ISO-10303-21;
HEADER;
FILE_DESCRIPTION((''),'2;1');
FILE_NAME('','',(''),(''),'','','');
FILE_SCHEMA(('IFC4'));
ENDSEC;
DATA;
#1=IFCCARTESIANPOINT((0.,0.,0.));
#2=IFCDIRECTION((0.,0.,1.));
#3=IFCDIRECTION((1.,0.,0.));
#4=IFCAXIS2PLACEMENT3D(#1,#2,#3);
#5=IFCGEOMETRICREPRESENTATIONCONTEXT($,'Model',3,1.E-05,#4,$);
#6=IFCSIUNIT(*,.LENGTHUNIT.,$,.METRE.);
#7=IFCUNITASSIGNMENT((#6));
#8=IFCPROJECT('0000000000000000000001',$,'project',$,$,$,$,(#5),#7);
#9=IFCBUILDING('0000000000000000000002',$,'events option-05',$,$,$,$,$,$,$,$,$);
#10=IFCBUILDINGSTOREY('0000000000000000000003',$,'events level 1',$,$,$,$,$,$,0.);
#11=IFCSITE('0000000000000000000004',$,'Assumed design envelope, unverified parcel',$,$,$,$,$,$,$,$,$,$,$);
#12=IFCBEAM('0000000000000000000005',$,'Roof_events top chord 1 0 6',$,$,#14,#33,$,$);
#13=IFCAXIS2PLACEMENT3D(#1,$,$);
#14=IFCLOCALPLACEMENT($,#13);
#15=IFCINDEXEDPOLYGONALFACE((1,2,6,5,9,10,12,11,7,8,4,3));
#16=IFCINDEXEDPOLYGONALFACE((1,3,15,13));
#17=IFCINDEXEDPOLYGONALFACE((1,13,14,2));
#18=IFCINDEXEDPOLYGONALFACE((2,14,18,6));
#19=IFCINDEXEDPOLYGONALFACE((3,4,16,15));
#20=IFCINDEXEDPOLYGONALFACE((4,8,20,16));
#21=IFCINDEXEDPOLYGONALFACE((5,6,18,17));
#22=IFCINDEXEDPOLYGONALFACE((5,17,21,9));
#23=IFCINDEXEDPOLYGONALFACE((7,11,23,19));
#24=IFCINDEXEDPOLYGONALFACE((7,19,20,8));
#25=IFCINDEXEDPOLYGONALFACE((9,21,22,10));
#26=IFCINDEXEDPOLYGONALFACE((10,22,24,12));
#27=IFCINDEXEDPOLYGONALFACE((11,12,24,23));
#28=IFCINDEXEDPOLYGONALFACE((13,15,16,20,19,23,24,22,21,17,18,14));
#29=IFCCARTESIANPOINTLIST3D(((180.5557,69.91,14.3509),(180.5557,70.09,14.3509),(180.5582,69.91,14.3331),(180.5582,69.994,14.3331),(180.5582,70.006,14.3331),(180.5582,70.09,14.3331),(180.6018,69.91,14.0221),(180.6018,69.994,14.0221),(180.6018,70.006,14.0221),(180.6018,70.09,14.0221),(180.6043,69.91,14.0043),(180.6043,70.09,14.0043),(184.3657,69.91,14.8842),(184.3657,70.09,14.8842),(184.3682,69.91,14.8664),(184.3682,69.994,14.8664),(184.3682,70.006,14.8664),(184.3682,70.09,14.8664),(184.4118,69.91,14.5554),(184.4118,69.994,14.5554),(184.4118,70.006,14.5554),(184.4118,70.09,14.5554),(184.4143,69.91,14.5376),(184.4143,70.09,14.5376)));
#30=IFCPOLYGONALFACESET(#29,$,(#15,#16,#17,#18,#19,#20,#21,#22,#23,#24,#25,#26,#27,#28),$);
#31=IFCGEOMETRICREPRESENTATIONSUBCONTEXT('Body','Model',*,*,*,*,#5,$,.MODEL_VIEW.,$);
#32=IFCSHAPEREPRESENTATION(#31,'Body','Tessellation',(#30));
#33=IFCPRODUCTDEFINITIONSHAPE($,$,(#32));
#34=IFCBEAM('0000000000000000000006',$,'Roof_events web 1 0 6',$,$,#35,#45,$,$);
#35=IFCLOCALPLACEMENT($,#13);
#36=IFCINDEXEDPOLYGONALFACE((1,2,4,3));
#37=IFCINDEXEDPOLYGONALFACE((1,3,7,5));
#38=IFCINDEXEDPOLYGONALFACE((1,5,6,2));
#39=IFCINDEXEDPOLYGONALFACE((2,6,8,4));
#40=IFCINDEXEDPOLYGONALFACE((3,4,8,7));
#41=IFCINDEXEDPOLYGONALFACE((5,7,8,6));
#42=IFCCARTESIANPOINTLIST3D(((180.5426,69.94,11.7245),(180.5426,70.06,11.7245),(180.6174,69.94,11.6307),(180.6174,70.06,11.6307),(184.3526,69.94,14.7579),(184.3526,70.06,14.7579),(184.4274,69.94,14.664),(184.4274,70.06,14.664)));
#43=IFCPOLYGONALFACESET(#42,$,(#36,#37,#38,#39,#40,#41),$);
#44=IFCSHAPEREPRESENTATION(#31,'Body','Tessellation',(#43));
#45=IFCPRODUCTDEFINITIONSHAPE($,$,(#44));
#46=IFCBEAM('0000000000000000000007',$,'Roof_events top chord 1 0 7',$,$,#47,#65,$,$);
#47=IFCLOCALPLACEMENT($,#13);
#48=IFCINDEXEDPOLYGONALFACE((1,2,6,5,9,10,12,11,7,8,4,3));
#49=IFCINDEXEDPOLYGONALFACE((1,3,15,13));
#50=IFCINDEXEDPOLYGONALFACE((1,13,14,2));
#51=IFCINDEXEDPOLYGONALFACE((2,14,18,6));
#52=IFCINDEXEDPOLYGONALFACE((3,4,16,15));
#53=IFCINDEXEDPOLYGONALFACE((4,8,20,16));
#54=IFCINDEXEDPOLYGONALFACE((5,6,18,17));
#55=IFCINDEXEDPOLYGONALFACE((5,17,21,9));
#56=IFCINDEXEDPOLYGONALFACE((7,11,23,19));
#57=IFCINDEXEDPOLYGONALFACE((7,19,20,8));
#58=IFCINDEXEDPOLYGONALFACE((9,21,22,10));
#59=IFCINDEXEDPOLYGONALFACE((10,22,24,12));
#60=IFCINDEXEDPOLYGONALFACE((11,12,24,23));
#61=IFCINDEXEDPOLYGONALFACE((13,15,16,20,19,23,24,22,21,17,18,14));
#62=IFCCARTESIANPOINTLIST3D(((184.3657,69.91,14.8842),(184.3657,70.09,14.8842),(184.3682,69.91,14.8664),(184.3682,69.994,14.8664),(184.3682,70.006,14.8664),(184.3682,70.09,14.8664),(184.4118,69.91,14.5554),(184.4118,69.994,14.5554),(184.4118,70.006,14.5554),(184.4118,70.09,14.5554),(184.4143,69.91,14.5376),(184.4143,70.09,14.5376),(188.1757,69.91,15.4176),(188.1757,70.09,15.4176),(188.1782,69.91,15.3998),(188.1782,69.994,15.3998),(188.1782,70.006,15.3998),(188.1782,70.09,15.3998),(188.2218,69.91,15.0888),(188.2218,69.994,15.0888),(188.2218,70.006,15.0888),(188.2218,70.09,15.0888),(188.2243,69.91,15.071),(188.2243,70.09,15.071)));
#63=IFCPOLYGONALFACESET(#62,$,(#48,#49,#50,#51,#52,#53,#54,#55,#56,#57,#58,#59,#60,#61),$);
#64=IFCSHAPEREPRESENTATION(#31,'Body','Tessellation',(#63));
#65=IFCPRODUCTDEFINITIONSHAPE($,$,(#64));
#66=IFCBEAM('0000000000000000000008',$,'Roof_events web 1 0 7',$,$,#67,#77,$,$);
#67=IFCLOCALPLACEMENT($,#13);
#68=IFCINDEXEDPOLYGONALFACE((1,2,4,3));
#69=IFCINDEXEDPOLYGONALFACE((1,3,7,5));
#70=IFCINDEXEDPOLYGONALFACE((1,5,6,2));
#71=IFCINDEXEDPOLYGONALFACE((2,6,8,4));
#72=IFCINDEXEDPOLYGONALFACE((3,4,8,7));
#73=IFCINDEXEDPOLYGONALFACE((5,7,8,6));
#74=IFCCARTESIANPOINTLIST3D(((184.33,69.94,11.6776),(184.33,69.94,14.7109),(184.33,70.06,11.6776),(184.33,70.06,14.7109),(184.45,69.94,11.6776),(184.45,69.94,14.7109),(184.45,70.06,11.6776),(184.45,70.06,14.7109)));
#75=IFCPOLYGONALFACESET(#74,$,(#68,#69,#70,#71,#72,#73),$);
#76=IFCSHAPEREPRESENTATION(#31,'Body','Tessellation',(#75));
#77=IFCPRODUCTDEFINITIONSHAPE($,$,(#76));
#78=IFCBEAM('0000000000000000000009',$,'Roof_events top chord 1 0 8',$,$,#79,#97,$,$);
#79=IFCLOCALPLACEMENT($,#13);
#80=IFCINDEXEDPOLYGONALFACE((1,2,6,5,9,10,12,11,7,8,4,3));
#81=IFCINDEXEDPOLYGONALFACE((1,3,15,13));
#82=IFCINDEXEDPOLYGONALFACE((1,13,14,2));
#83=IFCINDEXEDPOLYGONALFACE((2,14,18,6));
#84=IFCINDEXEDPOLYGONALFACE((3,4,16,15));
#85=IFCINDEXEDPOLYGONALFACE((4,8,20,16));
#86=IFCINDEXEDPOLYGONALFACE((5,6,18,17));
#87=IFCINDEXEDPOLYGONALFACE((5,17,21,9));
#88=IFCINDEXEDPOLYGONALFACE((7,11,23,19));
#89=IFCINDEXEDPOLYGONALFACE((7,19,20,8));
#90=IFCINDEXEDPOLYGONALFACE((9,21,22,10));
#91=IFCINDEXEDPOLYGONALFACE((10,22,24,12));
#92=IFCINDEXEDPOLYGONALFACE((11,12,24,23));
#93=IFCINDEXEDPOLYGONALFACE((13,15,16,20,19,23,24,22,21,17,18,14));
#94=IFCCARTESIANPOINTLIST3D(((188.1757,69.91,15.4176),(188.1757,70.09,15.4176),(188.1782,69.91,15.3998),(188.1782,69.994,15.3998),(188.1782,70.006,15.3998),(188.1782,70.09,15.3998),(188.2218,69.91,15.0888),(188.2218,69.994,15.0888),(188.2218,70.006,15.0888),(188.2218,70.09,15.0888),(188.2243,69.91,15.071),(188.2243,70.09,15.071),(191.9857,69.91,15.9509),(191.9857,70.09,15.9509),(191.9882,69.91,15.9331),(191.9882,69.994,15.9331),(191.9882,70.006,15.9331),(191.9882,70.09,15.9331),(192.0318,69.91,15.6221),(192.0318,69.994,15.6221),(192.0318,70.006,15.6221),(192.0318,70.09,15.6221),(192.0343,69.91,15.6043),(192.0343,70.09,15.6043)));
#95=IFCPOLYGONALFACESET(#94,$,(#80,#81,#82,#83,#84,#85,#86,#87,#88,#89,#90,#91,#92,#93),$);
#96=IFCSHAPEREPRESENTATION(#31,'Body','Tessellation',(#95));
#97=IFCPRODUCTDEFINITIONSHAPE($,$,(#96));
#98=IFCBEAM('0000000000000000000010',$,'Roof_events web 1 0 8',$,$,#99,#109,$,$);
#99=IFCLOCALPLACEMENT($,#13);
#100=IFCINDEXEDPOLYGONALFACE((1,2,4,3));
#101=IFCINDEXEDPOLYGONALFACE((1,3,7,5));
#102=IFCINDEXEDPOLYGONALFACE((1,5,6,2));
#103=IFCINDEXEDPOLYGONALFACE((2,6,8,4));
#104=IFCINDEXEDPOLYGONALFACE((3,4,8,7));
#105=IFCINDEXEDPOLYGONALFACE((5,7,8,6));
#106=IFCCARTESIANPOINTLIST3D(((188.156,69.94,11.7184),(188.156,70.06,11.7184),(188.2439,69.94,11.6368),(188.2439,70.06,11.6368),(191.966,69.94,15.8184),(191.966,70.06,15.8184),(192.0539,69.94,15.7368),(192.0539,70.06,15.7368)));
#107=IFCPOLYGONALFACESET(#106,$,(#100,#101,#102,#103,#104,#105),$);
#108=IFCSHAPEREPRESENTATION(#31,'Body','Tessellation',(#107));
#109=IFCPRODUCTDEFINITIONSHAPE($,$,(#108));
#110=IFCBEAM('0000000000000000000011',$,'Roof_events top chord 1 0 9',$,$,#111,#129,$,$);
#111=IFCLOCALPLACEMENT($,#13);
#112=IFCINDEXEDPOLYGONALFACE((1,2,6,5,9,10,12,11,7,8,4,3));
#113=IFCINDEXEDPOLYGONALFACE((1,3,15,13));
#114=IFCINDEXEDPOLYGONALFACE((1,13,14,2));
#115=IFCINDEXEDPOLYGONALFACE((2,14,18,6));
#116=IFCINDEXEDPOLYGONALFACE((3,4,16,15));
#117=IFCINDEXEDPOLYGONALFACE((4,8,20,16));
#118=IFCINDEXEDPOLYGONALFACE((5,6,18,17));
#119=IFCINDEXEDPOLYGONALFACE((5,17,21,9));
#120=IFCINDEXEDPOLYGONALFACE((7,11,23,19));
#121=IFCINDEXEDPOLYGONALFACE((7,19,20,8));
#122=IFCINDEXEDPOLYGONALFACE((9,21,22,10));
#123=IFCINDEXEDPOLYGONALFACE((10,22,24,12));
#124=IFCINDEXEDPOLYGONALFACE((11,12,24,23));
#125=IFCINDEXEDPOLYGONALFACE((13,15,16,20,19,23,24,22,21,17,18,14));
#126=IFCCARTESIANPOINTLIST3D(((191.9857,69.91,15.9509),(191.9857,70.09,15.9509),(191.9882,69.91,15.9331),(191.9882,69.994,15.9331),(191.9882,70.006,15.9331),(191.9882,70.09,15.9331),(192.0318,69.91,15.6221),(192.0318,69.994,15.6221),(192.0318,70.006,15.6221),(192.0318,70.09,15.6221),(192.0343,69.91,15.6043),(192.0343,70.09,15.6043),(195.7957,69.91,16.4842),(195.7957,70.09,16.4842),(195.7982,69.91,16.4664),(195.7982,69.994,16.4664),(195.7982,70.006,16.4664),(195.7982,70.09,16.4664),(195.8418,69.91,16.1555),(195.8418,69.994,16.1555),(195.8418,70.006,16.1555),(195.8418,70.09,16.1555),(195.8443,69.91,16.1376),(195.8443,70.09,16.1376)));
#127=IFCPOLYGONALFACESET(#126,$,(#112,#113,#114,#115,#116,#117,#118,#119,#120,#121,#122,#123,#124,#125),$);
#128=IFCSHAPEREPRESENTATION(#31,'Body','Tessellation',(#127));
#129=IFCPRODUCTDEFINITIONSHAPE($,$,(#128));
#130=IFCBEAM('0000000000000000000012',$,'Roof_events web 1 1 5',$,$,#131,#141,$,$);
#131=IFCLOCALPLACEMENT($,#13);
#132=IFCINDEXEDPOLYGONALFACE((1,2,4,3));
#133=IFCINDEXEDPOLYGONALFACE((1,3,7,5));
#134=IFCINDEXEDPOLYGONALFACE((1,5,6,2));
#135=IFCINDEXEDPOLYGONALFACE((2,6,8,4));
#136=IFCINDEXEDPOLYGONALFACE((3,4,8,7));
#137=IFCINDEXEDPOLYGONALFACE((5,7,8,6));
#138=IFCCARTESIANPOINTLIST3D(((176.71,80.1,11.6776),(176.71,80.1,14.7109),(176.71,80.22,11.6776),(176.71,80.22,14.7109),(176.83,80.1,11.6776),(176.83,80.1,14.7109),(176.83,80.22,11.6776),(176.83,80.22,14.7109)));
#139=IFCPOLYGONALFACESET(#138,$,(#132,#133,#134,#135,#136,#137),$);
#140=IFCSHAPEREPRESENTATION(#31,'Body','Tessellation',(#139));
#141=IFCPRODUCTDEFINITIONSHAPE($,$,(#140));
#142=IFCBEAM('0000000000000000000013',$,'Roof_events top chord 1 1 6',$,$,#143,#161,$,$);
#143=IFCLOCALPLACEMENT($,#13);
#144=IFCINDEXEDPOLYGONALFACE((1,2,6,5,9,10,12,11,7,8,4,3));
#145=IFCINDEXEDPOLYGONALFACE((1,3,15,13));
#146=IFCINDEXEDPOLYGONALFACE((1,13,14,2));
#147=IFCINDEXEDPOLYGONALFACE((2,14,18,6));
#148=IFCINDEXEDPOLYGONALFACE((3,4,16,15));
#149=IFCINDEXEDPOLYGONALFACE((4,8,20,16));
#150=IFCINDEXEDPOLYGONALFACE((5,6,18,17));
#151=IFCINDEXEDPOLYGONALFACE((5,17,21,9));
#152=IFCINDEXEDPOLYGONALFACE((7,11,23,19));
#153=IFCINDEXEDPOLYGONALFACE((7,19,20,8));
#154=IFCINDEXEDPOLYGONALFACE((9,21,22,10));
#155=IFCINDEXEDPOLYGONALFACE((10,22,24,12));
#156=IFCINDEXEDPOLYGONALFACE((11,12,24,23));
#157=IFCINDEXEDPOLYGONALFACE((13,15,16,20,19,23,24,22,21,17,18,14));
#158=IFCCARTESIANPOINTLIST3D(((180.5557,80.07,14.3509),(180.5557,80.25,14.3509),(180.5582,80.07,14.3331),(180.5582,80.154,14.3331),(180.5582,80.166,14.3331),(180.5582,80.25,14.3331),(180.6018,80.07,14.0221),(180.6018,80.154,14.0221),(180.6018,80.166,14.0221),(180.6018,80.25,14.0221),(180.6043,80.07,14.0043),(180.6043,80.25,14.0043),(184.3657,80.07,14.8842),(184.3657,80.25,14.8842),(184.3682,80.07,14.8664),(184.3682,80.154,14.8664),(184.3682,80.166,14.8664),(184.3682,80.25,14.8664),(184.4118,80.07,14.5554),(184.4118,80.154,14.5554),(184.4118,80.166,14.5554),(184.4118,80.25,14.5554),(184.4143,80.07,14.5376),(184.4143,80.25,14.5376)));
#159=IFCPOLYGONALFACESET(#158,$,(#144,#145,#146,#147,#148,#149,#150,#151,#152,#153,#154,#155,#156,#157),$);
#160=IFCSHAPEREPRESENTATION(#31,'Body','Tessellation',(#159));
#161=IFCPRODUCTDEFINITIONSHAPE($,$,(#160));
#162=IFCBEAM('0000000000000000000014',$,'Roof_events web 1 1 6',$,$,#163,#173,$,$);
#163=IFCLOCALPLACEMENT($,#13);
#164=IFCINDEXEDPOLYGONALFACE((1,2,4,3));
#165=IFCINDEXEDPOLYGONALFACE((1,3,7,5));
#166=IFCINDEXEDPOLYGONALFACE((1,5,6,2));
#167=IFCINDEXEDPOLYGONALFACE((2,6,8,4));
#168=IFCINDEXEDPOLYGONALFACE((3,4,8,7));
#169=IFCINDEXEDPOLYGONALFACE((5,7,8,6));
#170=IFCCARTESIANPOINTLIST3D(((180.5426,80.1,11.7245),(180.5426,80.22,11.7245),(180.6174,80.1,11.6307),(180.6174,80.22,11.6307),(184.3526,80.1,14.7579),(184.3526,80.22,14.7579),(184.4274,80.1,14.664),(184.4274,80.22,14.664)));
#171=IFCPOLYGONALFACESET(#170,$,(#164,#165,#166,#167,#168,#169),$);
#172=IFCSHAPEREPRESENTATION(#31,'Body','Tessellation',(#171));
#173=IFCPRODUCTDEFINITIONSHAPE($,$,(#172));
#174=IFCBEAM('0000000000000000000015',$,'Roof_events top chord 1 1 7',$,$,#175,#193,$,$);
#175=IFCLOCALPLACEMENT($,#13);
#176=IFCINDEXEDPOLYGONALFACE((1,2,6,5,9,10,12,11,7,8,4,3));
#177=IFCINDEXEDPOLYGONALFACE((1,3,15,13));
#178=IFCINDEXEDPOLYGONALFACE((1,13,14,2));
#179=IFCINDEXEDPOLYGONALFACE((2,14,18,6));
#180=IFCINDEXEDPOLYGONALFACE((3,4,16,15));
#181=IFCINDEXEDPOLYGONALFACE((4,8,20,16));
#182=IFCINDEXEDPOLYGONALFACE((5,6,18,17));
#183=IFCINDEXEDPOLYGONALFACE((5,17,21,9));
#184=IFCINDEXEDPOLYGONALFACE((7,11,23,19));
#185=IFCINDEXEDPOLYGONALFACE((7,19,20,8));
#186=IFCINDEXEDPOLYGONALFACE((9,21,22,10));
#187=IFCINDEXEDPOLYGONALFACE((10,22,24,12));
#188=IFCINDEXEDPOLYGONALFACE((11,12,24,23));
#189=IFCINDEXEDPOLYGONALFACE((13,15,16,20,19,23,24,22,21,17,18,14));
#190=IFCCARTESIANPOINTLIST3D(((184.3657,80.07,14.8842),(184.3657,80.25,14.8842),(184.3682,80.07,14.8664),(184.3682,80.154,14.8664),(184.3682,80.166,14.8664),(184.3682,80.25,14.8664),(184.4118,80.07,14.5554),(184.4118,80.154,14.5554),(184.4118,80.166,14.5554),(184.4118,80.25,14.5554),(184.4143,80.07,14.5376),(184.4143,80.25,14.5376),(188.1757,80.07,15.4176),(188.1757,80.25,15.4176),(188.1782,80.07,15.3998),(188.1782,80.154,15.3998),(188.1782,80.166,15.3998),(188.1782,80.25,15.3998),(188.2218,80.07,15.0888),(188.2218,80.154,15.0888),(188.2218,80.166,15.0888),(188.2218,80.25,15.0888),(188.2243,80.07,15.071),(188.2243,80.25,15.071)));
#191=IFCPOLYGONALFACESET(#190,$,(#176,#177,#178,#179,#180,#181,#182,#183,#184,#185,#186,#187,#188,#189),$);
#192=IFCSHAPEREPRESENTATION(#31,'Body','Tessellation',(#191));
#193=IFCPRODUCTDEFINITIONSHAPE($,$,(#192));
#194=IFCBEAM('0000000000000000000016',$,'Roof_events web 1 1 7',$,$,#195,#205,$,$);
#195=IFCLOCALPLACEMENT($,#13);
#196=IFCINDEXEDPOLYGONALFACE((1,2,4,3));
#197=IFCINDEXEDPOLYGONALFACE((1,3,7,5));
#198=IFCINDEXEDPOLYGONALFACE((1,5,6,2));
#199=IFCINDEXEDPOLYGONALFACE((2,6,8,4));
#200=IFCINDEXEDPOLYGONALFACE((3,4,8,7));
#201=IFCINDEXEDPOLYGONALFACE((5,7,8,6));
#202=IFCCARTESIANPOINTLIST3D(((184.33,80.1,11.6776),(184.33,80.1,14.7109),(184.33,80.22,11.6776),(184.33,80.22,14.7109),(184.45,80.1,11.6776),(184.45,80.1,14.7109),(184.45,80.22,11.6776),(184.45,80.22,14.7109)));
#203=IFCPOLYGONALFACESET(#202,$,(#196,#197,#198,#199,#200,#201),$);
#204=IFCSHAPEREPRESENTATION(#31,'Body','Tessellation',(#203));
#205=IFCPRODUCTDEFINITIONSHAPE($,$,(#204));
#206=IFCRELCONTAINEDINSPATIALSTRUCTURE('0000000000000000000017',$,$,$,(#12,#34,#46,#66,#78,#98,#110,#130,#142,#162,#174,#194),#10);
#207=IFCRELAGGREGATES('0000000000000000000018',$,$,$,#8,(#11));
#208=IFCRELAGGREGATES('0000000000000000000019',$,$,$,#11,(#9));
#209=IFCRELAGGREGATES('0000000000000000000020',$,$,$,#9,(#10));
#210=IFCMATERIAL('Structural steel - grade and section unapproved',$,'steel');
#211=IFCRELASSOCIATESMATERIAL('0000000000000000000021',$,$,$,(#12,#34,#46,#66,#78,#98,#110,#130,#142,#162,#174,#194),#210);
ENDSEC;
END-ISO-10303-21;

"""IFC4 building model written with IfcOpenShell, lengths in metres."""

from ifc_helpers import new_model, si_unit, frame, origin_with_axes, place, context, subcontext, project, spatial, rectangle, i_section, extrude, material, element, save


model = new_model("IFC4")

# Units and contexts
model_context = context("Model", 3, precision=1e-05, world=origin_with_axes())
body_context = subcontext(model_context, "Body", "Model", "MODEL_VIEW")
ifc_project = project(units=[si_unit("LENGTHUNIT", "METRE")], contexts=[model_context])

# Site, building, storey
site = spatial("IfcSite", under=ifc_project, Name="Assumed design envelope, unverified parcel")
building = spatial("IfcBuilding", under=site, Name="events option-05")
storey = spatial("IfcBuildingStorey", under=building, Name="events level 1", Elevation=0.0)

# Beams
ifc_material_1 = material(Name="Structural steel - grade and section unapproved", Category="steel")
beam_1_placement = place(None, frame((180.58, 70.0, 14.1776), z_axis=(0.990344, 0.0, 0.138631), x_axis=(0.0, 1.0, 0.0)))
element("IfcBeam", 1, at=beam_1_placement, inside=storey, material=ifc_material_1, Name="Roof_events top chord 1 0 6", context=body_context, shape_type="SweptSolid", body=[
    extrude(i_section(OverallWidth=0.18, OverallDepth=0.35, WebThickness=0.012, FlangeThickness=0.018, FilletRadius=0.0), origin_with_axes(), (0.0, 0.0, 1.0), 3.8471),
])
beam_2_placement = place(None, frame((180.58, 70.0, 11.6776), z_axis=(0.782336, 0.0, 0.622857), x_axis=(0.0, 1.0, 0.0)))
element("IfcBeam", 2, at=beam_2_placement, inside=storey, material=ifc_material_1, Name="Roof_events web 1 0 6", context=body_context, shape_type="SweptSolid", body=[
    extrude(rectangle(XDim=0.12, YDim=0.12), origin_with_axes(), (0.0, 0.0, 1.0), 4.87),
])
beam_3_placement = place(None, frame((184.39, 70.0, 14.7109), z_axis=(0.990344, 0.0, 0.138631), x_axis=(0.0, 1.0, 0.0)))
element("IfcBeam", 3, at=beam_3_placement, inside=storey, material=ifc_material_1, Name="Roof_events top chord 1 0 7", context=body_context, shape_type="SweptSolid", body=[
    extrude(i_section(OverallWidth=0.18, OverallDepth=0.35, WebThickness=0.012, FlangeThickness=0.018, FilletRadius=0.0), origin_with_axes(), (0.0, 0.0, 1.0), 3.8471),
])
beam_4_placement = place(None, frame((184.39, 70.0, 11.6776), z_axis=(0.0, 0.0, 1.0), x_axis=(-1.0, 0.0, 0.0)))
element("IfcBeam", 4, at=beam_4_placement, inside=storey, material=ifc_material_1, Name="Roof_events web 1 0 7", context=body_context, shape_type="SweptSolid", body=[
    extrude(rectangle(XDim=0.12, YDim=0.12), origin_with_axes(), (0.0, 0.0, 1.0), 3.0333),
])
beam_5_placement = place(None, frame((188.2, 70.0, 15.2443), z_axis=(0.990344, 0.0, 0.138631), x_axis=(0.0, 1.0, 0.0)))
element("IfcBeam", 5, at=beam_5_placement, inside=storey, material=ifc_material_1, Name="Roof_events top chord 1 0 8", context=body_context, shape_type="SweptSolid", body=[
    extrude(i_section(OverallWidth=0.18, OverallDepth=0.35, WebThickness=0.012, FlangeThickness=0.018, FilletRadius=0.0), origin_with_axes(), (0.0, 0.0, 1.0), 3.8471),
])
beam_6_placement = place(None, frame((188.2, 70.0, 11.6776), z_axis=(0.680725, 0.0, 0.732539), x_axis=(0.0, 1.0, 0.0)))
element("IfcBeam", 6, at=beam_6_placement, inside=storey, material=ifc_material_1, Name="Roof_events web 1 0 8", context=body_context, shape_type="SweptSolid", body=[
    extrude(rectangle(XDim=0.12, YDim=0.12), origin_with_axes(), (0.0, 0.0, 1.0), 5.597),
])
beam_7_placement = place(None, frame((192.01, 70.0, 15.7776), z_axis=(0.990344, 0.0, 0.138631), x_axis=(0.0, 1.0, 0.0)))
element("IfcBeam", 7, at=beam_7_placement, inside=storey, material=ifc_material_1, Name="Roof_events top chord 1 0 9", context=body_context, shape_type="SweptSolid", body=[
    extrude(i_section(OverallWidth=0.18, OverallDepth=0.35, WebThickness=0.012, FlangeThickness=0.018, FilletRadius=0.0), origin_with_axes(), (0.0, 0.0, 1.0), 3.8472),
])
beam_8_placement = place(None, frame((176.77, 80.16, 11.6776), z_axis=(0.0, 0.0, 1.0), x_axis=(-1.0, 0.0, 0.0)))
element("IfcBeam", 8, at=beam_8_placement, inside=storey, material=ifc_material_1, Name="Roof_events web 1 1 5", context=body_context, shape_type="SweptSolid", body=[
    extrude(rectangle(XDim=0.12, YDim=0.12), origin_with_axes(), (0.0, 0.0, 1.0), 3.0333),
])
beam_9_placement = place(None, frame((180.58, 80.16, 14.1776), z_axis=(0.990344, 0.0, 0.138631), x_axis=(0.0, 1.0, 0.0)))
element("IfcBeam", 9, at=beam_9_placement, inside=storey, material=ifc_material_1, Name="Roof_events top chord 1 1 6", context=body_context, shape_type="SweptSolid", body=[
    extrude(i_section(OverallWidth=0.18, OverallDepth=0.35, WebThickness=0.012, FlangeThickness=0.018, FilletRadius=0.0), origin_with_axes(), (0.0, 0.0, 1.0), 3.8471),
])
beam_10_placement = place(None, frame((180.58, 80.16, 11.6776), z_axis=(0.782336, 0.0, 0.622857), x_axis=(0.0, 1.0, 0.0)))
element("IfcBeam", 10, at=beam_10_placement, inside=storey, material=ifc_material_1, Name="Roof_events web 1 1 6", context=body_context, shape_type="SweptSolid", body=[
    extrude(rectangle(XDim=0.12, YDim=0.12), origin_with_axes(), (0.0, 0.0, 1.0), 4.87),
])
beam_11_placement = place(None, frame((184.39, 80.16, 14.7109), z_axis=(0.990344, 0.0, 0.138631), x_axis=(0.0, 1.0, 0.0)))
element("IfcBeam", 11, at=beam_11_placement, inside=storey, material=ifc_material_1, Name="Roof_events top chord 1 1 7", context=body_context, shape_type="SweptSolid", body=[
    extrude(i_section(OverallWidth=0.18, OverallDepth=0.35, WebThickness=0.012, FlangeThickness=0.018, FilletRadius=0.0), origin_with_axes(), (0.0, 0.0, 1.0), 3.8471),
])
beam_12_placement = place(None, frame((184.39, 80.16, 11.6776), z_axis=(0.0, 0.0, 1.0), x_axis=(-1.0, 0.0, 0.0)))
element("IfcBeam", 12, at=beam_12_placement, inside=storey, material=ifc_material_1, Name="Roof_events web 1 1 7", context=body_context, shape_type="SweptSolid", body=[
    extrude(rectangle(XDim=0.12, YDim=0.12), origin_with_axes(), (0.0, 0.0, 1.0), 3.0333),
])

save(model, "model.ifc")
